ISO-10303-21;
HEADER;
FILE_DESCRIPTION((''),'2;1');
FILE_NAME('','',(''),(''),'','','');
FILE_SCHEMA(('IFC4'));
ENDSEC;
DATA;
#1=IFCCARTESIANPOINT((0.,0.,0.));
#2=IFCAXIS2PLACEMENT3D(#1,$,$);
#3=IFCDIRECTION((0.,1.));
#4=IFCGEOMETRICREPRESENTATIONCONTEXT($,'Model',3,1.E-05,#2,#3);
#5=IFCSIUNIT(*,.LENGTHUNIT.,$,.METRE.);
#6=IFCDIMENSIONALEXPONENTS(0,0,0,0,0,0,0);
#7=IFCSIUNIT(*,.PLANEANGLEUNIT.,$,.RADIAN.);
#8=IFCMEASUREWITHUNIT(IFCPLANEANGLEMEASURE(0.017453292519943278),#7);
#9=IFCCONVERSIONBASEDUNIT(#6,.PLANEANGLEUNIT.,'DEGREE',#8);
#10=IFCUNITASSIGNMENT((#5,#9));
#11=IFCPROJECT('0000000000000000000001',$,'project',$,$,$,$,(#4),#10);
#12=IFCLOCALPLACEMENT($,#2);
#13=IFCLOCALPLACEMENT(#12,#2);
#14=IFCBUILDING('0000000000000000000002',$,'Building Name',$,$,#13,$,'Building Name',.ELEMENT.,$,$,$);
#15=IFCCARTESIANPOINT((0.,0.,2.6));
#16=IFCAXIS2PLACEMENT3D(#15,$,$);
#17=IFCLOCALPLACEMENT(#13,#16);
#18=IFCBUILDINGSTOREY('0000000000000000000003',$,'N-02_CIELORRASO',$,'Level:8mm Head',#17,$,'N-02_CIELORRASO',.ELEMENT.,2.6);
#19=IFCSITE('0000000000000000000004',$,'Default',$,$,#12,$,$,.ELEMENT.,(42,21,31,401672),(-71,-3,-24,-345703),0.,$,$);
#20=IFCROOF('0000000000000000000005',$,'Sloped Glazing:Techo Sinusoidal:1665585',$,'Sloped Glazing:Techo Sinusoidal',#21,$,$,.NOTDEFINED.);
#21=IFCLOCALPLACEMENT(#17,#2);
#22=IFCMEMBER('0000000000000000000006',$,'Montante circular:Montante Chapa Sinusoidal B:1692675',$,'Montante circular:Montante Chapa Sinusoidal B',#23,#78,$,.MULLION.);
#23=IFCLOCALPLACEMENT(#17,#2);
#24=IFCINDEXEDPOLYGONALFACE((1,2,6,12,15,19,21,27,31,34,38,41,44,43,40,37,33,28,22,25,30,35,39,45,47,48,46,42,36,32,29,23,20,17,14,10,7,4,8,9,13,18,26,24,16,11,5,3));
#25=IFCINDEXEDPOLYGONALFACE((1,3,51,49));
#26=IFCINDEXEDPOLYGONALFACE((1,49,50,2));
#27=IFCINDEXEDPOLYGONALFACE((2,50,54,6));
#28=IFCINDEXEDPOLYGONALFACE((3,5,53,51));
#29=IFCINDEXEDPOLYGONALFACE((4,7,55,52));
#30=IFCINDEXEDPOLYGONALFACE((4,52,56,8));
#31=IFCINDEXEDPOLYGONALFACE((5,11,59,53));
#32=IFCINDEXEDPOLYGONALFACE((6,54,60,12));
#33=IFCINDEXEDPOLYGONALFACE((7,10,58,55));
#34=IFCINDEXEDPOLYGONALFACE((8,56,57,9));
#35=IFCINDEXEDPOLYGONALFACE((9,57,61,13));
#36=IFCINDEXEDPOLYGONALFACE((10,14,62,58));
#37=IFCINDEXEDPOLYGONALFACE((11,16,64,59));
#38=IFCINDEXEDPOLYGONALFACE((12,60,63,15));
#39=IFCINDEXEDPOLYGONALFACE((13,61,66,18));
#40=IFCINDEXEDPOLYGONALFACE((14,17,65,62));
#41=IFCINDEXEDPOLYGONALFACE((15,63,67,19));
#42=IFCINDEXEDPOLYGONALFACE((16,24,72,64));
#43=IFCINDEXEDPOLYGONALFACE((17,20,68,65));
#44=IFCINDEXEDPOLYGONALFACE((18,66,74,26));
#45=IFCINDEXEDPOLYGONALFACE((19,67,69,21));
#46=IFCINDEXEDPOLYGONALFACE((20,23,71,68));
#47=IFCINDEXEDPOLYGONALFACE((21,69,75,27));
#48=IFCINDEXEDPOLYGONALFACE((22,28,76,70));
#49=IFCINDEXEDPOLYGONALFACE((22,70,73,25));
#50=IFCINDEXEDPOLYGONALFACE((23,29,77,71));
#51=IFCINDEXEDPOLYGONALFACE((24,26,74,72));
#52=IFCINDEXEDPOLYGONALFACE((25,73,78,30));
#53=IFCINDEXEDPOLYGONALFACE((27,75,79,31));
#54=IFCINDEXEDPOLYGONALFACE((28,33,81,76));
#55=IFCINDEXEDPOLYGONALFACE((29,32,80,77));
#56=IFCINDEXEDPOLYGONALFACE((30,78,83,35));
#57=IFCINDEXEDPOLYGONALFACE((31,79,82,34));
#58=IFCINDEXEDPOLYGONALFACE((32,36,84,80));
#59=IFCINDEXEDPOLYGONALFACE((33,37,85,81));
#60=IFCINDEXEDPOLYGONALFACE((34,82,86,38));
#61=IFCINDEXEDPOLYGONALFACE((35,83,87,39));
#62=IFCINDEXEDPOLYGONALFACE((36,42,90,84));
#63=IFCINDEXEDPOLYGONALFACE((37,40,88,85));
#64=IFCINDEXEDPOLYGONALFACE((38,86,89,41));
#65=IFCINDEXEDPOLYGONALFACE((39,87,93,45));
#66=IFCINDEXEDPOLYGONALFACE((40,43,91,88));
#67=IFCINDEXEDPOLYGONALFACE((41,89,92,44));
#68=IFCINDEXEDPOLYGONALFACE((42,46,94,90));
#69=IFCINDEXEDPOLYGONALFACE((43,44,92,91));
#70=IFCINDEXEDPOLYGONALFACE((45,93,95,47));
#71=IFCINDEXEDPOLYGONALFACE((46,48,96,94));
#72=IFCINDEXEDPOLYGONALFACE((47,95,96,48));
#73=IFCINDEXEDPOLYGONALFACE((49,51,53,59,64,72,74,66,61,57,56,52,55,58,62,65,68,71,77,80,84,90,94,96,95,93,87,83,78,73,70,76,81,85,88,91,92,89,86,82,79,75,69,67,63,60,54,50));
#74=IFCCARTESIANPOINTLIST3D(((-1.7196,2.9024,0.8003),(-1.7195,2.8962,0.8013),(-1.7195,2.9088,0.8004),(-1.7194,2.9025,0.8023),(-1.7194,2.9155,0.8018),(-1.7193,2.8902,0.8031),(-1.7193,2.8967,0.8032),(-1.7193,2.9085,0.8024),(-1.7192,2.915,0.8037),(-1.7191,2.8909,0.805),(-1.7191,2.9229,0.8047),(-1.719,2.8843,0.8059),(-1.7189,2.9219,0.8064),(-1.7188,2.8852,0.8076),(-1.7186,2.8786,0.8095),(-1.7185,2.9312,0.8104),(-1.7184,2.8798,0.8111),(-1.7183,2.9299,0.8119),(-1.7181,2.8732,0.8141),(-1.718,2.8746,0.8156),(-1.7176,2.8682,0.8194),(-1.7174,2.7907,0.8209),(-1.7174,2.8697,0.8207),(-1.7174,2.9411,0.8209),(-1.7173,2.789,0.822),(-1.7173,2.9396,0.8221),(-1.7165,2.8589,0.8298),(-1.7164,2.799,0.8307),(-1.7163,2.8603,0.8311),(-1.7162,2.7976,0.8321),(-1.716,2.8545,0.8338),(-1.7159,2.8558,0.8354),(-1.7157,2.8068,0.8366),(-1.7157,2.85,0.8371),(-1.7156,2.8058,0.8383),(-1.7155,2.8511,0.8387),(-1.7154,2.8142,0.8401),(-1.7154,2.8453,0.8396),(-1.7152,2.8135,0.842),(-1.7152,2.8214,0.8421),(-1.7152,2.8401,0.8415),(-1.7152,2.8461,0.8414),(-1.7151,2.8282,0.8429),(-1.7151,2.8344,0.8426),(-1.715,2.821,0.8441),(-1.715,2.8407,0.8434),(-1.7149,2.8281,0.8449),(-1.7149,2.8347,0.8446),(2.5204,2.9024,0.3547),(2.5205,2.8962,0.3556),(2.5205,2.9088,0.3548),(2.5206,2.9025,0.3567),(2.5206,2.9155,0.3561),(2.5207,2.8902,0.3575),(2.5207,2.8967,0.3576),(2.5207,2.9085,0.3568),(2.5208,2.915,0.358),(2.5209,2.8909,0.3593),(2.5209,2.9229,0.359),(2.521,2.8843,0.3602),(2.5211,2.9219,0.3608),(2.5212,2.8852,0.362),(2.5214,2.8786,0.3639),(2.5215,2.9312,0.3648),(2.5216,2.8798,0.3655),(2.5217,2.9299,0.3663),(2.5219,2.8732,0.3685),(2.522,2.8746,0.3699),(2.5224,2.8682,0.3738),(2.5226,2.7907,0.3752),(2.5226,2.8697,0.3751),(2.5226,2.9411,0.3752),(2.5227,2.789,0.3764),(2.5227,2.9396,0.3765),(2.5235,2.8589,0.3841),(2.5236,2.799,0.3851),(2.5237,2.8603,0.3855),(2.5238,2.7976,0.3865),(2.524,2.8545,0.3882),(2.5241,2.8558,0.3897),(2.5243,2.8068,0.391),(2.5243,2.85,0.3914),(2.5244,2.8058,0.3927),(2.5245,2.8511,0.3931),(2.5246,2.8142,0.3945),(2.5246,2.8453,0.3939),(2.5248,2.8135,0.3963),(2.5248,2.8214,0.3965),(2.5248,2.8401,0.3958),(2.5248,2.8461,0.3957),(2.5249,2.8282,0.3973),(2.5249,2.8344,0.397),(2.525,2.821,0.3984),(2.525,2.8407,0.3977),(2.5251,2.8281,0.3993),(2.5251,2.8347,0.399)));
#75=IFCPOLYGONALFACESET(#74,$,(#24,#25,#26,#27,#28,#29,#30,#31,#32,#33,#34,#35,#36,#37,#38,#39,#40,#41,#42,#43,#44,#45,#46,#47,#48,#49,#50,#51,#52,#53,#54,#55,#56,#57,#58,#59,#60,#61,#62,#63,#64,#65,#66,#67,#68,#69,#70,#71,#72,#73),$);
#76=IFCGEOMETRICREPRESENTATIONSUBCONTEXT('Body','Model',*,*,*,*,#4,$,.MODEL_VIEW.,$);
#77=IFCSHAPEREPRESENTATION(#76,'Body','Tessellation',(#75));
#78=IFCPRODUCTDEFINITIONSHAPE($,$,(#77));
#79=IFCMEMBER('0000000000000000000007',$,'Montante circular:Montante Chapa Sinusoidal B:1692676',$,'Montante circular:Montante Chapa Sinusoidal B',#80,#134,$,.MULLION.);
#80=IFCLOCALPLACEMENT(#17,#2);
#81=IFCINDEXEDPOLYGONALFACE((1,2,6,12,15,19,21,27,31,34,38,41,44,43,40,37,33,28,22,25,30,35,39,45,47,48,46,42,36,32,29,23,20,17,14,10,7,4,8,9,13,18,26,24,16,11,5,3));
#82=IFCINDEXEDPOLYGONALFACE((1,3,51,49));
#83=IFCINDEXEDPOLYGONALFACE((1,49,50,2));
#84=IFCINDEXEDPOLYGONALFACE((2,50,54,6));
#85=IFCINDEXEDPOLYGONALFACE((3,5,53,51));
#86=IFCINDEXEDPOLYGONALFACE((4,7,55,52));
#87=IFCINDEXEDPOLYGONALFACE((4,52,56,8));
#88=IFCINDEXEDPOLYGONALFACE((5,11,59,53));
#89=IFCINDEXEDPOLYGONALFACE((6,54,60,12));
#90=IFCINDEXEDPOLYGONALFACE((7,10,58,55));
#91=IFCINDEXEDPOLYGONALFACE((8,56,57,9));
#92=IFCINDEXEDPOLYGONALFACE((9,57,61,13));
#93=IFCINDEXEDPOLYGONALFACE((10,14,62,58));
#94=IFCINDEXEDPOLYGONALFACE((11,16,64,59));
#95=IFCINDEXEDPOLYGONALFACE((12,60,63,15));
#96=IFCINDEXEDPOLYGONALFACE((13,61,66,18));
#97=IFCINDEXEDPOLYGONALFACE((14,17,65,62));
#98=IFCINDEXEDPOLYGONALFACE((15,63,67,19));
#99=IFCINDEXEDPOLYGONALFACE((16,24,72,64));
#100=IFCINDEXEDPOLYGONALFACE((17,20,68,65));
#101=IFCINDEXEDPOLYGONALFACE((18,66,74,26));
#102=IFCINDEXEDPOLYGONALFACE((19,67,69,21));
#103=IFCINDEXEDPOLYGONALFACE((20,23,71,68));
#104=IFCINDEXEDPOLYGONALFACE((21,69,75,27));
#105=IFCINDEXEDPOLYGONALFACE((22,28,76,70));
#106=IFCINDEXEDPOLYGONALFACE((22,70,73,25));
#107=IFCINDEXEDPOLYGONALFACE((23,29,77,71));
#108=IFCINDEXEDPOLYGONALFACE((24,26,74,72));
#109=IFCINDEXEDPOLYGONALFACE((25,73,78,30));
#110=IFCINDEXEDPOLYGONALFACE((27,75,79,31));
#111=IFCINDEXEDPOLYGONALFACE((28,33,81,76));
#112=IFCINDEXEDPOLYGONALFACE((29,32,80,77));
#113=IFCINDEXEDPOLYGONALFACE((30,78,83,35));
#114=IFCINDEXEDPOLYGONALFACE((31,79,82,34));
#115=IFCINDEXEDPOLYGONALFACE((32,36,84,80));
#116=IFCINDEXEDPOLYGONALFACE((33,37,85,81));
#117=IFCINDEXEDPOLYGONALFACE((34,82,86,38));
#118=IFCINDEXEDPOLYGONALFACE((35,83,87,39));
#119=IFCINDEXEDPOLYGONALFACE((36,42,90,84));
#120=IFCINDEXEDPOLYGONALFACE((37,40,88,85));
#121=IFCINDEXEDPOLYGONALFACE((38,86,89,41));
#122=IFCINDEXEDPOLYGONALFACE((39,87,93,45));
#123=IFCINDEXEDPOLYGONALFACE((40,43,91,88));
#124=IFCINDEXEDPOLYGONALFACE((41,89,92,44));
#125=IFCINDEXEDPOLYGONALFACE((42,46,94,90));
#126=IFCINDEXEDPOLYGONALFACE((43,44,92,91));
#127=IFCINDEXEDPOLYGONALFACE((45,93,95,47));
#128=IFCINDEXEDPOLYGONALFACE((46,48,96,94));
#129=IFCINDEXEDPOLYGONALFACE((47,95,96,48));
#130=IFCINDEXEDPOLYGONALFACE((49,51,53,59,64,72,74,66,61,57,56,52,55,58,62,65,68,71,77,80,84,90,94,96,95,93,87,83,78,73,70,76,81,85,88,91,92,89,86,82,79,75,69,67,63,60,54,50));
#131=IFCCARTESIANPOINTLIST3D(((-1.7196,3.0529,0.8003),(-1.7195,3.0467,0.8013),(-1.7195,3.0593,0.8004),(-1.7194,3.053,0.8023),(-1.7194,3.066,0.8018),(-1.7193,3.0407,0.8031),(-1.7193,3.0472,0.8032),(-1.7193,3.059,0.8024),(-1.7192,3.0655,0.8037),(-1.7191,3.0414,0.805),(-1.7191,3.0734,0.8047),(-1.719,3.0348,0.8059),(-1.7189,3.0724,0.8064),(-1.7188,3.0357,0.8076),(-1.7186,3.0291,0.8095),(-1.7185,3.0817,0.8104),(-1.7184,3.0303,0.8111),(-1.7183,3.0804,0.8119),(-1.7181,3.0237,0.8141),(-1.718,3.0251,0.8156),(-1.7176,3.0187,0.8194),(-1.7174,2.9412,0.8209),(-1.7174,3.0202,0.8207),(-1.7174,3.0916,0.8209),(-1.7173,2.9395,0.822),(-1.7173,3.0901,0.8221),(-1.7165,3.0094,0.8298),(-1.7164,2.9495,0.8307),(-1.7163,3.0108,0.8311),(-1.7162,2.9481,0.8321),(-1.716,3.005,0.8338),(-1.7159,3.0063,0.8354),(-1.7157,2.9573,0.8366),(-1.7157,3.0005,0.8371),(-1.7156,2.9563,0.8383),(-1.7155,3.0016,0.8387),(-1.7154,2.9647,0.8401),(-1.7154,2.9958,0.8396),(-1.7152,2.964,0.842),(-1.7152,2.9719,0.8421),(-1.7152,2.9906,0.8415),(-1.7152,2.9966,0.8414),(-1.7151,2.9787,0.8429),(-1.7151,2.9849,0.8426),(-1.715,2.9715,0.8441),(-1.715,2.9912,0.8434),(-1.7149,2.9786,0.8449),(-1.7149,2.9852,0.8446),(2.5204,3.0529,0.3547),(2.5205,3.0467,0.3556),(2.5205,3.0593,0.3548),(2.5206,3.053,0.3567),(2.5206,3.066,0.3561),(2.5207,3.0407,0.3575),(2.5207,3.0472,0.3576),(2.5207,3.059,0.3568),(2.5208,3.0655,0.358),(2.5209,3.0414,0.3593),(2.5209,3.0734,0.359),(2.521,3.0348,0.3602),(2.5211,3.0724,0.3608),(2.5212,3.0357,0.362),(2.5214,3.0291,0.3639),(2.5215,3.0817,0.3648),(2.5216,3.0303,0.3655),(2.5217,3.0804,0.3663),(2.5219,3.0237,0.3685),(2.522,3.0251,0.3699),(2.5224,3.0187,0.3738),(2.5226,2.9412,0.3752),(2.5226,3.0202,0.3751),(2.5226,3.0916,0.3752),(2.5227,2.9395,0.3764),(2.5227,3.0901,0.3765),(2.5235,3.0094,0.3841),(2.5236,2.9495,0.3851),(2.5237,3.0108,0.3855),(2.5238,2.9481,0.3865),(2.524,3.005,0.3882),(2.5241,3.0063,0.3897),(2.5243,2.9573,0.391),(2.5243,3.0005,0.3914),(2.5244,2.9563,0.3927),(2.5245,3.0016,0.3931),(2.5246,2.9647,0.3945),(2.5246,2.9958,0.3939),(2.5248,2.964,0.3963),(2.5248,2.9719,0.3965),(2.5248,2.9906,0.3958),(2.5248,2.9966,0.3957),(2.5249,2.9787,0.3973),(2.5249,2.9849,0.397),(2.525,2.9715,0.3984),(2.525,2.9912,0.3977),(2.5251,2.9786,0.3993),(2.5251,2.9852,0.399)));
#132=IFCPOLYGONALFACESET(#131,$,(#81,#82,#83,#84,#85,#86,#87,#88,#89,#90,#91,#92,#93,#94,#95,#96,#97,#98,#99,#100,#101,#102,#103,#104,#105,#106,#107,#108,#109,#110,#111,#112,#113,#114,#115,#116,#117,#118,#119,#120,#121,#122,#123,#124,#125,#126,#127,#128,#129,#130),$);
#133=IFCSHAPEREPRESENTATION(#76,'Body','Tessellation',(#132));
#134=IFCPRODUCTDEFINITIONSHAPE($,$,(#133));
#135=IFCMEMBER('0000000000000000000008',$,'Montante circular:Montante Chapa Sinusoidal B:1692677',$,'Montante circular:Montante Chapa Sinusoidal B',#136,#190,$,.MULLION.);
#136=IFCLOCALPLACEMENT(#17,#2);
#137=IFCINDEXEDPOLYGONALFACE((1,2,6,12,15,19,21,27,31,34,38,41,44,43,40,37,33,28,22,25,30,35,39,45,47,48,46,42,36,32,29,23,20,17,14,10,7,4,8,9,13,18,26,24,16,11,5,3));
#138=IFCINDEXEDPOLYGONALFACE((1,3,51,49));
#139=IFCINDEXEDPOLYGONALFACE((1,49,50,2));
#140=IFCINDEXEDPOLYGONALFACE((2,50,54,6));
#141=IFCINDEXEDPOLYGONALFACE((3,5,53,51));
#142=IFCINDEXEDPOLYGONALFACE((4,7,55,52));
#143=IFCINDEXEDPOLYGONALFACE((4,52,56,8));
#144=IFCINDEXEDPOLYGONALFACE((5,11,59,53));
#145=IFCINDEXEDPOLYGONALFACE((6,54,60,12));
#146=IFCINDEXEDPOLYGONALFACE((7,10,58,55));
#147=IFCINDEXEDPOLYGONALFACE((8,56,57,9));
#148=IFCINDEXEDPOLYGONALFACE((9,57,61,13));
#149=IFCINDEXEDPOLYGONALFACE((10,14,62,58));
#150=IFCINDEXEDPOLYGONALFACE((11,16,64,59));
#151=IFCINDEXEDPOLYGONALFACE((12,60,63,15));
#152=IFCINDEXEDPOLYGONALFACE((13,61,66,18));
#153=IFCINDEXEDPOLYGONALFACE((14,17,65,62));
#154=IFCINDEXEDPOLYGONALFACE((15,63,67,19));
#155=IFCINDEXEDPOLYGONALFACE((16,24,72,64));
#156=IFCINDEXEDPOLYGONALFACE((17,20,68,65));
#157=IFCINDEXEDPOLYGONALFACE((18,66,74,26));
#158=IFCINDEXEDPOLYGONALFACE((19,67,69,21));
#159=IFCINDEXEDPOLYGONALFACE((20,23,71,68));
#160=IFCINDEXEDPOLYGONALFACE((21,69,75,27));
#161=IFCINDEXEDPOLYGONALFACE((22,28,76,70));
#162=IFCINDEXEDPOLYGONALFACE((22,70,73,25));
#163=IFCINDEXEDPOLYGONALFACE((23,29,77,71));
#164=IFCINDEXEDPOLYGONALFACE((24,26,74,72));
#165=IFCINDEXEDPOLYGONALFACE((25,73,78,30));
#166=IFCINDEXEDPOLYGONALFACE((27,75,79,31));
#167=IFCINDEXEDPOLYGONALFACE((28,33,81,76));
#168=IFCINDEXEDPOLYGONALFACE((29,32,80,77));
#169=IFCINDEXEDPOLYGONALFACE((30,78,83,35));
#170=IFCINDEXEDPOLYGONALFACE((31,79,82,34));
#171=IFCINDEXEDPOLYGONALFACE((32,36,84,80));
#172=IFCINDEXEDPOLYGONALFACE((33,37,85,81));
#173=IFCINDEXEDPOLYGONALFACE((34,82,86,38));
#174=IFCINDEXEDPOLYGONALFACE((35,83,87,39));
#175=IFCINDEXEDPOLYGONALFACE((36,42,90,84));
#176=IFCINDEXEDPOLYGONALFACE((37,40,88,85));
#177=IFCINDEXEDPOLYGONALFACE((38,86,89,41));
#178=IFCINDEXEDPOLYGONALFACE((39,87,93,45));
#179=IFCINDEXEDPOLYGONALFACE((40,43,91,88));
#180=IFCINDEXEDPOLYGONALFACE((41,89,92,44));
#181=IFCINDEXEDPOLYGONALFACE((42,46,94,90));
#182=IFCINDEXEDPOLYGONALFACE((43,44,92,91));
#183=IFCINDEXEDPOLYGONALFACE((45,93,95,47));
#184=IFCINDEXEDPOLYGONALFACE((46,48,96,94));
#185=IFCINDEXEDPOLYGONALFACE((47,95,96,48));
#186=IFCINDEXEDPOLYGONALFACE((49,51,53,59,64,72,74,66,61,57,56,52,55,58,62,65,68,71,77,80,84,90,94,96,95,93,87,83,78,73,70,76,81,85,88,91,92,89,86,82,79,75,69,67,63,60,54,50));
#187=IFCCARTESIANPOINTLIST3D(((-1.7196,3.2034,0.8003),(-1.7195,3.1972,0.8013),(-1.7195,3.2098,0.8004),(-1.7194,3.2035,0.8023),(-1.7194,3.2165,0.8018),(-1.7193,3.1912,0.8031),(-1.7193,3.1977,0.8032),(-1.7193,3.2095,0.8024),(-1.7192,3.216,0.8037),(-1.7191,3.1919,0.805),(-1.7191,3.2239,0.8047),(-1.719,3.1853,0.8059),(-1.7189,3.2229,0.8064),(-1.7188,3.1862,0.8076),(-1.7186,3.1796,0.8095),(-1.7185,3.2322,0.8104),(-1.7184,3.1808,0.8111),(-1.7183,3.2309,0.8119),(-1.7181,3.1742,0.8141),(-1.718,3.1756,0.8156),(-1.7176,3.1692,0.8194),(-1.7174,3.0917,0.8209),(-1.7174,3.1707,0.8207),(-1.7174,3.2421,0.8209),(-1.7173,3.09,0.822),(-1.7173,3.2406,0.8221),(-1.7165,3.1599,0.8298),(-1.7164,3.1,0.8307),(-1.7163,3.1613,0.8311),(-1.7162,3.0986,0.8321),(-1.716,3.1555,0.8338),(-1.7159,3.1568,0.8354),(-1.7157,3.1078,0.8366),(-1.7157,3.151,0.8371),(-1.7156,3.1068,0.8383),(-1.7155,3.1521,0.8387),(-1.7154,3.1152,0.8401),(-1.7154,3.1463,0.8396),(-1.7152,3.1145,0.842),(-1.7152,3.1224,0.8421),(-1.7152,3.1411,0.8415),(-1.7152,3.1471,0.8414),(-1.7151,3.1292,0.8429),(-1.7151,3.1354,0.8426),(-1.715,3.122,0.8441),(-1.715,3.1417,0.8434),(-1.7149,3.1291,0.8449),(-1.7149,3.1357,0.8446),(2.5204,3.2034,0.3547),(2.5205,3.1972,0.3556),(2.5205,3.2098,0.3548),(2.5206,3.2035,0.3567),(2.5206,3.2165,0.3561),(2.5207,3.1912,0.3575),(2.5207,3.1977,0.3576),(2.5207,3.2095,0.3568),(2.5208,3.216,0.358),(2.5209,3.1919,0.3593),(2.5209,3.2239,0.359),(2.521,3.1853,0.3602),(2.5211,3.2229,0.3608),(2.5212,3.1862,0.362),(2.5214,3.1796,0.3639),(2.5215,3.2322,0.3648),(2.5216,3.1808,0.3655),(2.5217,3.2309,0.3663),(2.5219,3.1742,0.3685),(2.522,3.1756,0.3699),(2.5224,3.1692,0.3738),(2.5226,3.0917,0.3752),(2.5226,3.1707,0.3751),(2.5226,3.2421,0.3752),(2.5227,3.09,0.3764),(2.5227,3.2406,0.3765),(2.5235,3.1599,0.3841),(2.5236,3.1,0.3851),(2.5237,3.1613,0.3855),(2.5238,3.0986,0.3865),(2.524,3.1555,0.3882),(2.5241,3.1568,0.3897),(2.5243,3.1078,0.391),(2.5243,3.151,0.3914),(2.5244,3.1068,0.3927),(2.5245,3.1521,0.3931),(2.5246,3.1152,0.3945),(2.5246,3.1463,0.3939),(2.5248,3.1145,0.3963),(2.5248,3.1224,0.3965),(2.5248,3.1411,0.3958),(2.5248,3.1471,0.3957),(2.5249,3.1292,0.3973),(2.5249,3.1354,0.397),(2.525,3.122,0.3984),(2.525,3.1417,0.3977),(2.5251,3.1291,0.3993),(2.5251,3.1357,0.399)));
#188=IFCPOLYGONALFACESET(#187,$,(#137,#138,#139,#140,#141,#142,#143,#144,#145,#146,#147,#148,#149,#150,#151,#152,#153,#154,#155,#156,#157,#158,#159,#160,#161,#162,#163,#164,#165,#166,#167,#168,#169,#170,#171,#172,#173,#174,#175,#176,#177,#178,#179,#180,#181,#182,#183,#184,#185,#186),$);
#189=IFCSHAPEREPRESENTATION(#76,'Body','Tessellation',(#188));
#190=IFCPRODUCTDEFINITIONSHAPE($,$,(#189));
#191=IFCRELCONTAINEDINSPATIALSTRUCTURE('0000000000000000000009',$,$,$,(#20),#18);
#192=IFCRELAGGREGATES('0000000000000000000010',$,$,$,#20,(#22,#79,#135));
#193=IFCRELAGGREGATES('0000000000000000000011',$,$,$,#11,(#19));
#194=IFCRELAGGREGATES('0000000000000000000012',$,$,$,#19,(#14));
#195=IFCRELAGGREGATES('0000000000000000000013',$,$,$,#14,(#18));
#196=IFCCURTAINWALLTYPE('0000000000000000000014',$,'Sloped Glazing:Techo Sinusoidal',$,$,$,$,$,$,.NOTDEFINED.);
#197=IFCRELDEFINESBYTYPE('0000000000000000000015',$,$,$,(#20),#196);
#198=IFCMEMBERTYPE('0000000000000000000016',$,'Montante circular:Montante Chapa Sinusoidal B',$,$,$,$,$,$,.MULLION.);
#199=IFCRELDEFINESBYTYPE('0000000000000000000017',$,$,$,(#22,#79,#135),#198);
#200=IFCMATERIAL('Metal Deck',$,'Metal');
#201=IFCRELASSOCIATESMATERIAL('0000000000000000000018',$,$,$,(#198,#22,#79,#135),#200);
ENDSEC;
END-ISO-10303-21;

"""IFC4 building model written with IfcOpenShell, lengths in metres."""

from ifc_helpers import new_model, entity, si_unit, converted_unit, direction, frame, origin, place, context, subcontext, project, spatial, indexed_curve, outline, extrude, source, transform, mapped, material, type_object, type_shapes, element, aggregate, save


model = new_model("IFC4")

# Units and contexts
model_context = context("Model", 3, precision=1e-05, world=origin(), true_north=direction((0.0, 1.0)))
body_context = subcontext(model_context, "Body", "Model", "MODEL_VIEW")
ifc_project = project(units=[si_unit("LENGTHUNIT", "METRE"), converted_unit("PLANEANGLEUNIT", "DEGREE", entity("IfcPlaneAngleMeasure", 0.017453292519943278), si_unit("PLANEANGLEUNIT", "RADIAN"), dimensions=[0, 0, 0, 0, 0, 0, 0])], contexts=[model_context])

# Site, building, storey
site_placement = place(None, origin())
site = spatial("IfcSite", under=ifc_project, at=site_placement, Name="Default", CompositionType="ELEMENT", RefLatitude=(42, 21, 31, 401672), RefLongitude=(-71, -3, -24, -345703), RefElevation=0.0)
building_placement = place(site_placement, origin())
building = spatial("IfcBuilding", under=site, at=building_placement, Name="Building Name", LongName="Building Name", CompositionType="ELEMENT")
storey_placement = place(building_placement, frame((0.0, 0.0, 2.6)))
storey = spatial("IfcBuildingStorey", under=building, at=storey_placement, Name="N-02_CIELORRASO", ObjectType="Level:8mm Head", LongName="N-02_CIELORRASO", CompositionType="ELEMENT", Elevation=2.6)

# Roof, members
curtain_wall_type = type_object("IfcCurtainWallType", Name="Sloped Glazing:Techo Sinusoidal", PredefinedType="NOTDEFINED")
roof_placement = place(storey_placement, frame((0.0, 0.0, -2.6)))
roof = element("IfcRoof", 1, at=roof_placement, inside=storey, type_object=curtain_wall_type, Name="Sloped Glazing:Techo Sinusoidal:1665585", ObjectType="Sloped Glazing:Techo Sinusoidal", PredefinedType="NOTDEFINED")
ifc_material_1 = material(Name="Metal Deck", Category="Metal")
member_type = type_object("IfcMemberType", Name="Montante circular:Montante Chapa Sinusoidal B", PredefinedType="MULLION", material=ifc_material_1)
shared_shape_1 = source(origin(), body_context, "Body", "SweptSolid", [
    extrude(outline(indexed_curve([(0.0595, -0.0443), (0.0615, -0.0443), (0.0603, -0.031), (0.0572, -0.0213), (0.053, -0.0138), (0.0481, -0.0078), (0.0427, -0.003), (0.0372, 0.0005), (0.0315, 0.0029), (0.0259, 0.0044), (0.0203, 0.0051), (0.0146, 0.005), (0.0084, 0.0041), (-0.0053, 0.0009), (-0.0123, -0.0005), (-0.0191, -0.0012), (-0.0256, -0.001), (-0.0317, 0.0001), (-0.0375, 0.0019), (-0.0428, 0.0046), (-0.0477, 0.0081), (-0.0522, 0.0128), (-0.0563, 0.0191), (-0.0597, 0.0282), (-0.0617, 0.0421), (-0.0637, 0.042), (-0.0616, 0.0277), (-0.0581, 0.0182), (-0.0537, 0.0116), (-0.049, 0.0066), (-0.0438, 0.0028), (-0.0382, 0.0001), (-0.0322, -0.0019), (-0.0258, -0.003), (-0.019, -0.0032), (-0.012, -0.0025), (-0.0048, -0.0011), (0.0088, 0.0021), (0.0147, 0.003), (0.0202, 0.0031), (0.0255, 0.0024), (0.0309, 0.001), (0.0362, -0.0013), (0.0415, -0.0046), (0.0466, -0.0092), (0.0513, -0.0149), (0.0554, -0.0221), (0.0584, -0.0314), (0.0595, -0.0443)], self_intersect=False)), frame((-0.007, 0.0228, -4.2634), z_axis=(0.0, 0.0, 1.0), x_axis=(-0.819152, -0.573576, 0.0)), (0.0, 0.0, 1.0), 4.2634),
])
type_shapes(member_type, [shared_shape_1])
member_1_placement = place(roof_placement, frame((-1.7148, 2.8719, 3.4456), z_axis=(-0.994522, 0.0, 0.104528), x_axis=(0.0, 1.0, 0.0)))
member_1 = element("IfcMember", 2, at=member_1_placement, type_object=member_type, material=ifc_material_1, Name="Montante circular:Montante Chapa Sinusoidal B:1692675", ObjectType="Montante circular:Montante Chapa Sinusoidal B", PredefinedType="MULLION", context=body_context, shape_type="MappedRepresentation", body=[
    mapped(shared_shape_1, transform((0.0, 0.0, 0.0), scale=1.0)),
])
member_2_placement = place(roof_placement, frame((-1.7148, 3.0224, 3.4456), z_axis=(-0.994522, 0.0, 0.104528), x_axis=(0.0, 1.0, 0.0)))
member_2 = element("IfcMember", 3, at=member_2_placement, type_object=member_type, material=ifc_material_1, Name="Montante circular:Montante Chapa Sinusoidal B:1692676", ObjectType="Montante circular:Montante Chapa Sinusoidal B", PredefinedType="MULLION", context=body_context, shape_type="MappedRepresentation", body=[
    mapped(shared_shape_1, transform((0.0, 0.0, 0.0), scale=1.0)),
])
member_3_placement = place(roof_placement, frame((-1.7148, 3.1729, 3.4456), z_axis=(-0.994522, 0.0, 0.104528), x_axis=(0.0, 1.0, 0.0)))
member_3 = element("IfcMember", 4, at=member_3_placement, type_object=member_type, material=ifc_material_1, Name="Montante circular:Montante Chapa Sinusoidal B:1692677", ObjectType="Montante circular:Montante Chapa Sinusoidal B", PredefinedType="MULLION", context=body_context, shape_type="MappedRepresentation", body=[
    mapped(shared_shape_1, transform((0.0, 0.0, 0.0), scale=1.0)),
])
aggregate(roof, [member_1, member_2, member_3])

save(model, "model.ifc")
